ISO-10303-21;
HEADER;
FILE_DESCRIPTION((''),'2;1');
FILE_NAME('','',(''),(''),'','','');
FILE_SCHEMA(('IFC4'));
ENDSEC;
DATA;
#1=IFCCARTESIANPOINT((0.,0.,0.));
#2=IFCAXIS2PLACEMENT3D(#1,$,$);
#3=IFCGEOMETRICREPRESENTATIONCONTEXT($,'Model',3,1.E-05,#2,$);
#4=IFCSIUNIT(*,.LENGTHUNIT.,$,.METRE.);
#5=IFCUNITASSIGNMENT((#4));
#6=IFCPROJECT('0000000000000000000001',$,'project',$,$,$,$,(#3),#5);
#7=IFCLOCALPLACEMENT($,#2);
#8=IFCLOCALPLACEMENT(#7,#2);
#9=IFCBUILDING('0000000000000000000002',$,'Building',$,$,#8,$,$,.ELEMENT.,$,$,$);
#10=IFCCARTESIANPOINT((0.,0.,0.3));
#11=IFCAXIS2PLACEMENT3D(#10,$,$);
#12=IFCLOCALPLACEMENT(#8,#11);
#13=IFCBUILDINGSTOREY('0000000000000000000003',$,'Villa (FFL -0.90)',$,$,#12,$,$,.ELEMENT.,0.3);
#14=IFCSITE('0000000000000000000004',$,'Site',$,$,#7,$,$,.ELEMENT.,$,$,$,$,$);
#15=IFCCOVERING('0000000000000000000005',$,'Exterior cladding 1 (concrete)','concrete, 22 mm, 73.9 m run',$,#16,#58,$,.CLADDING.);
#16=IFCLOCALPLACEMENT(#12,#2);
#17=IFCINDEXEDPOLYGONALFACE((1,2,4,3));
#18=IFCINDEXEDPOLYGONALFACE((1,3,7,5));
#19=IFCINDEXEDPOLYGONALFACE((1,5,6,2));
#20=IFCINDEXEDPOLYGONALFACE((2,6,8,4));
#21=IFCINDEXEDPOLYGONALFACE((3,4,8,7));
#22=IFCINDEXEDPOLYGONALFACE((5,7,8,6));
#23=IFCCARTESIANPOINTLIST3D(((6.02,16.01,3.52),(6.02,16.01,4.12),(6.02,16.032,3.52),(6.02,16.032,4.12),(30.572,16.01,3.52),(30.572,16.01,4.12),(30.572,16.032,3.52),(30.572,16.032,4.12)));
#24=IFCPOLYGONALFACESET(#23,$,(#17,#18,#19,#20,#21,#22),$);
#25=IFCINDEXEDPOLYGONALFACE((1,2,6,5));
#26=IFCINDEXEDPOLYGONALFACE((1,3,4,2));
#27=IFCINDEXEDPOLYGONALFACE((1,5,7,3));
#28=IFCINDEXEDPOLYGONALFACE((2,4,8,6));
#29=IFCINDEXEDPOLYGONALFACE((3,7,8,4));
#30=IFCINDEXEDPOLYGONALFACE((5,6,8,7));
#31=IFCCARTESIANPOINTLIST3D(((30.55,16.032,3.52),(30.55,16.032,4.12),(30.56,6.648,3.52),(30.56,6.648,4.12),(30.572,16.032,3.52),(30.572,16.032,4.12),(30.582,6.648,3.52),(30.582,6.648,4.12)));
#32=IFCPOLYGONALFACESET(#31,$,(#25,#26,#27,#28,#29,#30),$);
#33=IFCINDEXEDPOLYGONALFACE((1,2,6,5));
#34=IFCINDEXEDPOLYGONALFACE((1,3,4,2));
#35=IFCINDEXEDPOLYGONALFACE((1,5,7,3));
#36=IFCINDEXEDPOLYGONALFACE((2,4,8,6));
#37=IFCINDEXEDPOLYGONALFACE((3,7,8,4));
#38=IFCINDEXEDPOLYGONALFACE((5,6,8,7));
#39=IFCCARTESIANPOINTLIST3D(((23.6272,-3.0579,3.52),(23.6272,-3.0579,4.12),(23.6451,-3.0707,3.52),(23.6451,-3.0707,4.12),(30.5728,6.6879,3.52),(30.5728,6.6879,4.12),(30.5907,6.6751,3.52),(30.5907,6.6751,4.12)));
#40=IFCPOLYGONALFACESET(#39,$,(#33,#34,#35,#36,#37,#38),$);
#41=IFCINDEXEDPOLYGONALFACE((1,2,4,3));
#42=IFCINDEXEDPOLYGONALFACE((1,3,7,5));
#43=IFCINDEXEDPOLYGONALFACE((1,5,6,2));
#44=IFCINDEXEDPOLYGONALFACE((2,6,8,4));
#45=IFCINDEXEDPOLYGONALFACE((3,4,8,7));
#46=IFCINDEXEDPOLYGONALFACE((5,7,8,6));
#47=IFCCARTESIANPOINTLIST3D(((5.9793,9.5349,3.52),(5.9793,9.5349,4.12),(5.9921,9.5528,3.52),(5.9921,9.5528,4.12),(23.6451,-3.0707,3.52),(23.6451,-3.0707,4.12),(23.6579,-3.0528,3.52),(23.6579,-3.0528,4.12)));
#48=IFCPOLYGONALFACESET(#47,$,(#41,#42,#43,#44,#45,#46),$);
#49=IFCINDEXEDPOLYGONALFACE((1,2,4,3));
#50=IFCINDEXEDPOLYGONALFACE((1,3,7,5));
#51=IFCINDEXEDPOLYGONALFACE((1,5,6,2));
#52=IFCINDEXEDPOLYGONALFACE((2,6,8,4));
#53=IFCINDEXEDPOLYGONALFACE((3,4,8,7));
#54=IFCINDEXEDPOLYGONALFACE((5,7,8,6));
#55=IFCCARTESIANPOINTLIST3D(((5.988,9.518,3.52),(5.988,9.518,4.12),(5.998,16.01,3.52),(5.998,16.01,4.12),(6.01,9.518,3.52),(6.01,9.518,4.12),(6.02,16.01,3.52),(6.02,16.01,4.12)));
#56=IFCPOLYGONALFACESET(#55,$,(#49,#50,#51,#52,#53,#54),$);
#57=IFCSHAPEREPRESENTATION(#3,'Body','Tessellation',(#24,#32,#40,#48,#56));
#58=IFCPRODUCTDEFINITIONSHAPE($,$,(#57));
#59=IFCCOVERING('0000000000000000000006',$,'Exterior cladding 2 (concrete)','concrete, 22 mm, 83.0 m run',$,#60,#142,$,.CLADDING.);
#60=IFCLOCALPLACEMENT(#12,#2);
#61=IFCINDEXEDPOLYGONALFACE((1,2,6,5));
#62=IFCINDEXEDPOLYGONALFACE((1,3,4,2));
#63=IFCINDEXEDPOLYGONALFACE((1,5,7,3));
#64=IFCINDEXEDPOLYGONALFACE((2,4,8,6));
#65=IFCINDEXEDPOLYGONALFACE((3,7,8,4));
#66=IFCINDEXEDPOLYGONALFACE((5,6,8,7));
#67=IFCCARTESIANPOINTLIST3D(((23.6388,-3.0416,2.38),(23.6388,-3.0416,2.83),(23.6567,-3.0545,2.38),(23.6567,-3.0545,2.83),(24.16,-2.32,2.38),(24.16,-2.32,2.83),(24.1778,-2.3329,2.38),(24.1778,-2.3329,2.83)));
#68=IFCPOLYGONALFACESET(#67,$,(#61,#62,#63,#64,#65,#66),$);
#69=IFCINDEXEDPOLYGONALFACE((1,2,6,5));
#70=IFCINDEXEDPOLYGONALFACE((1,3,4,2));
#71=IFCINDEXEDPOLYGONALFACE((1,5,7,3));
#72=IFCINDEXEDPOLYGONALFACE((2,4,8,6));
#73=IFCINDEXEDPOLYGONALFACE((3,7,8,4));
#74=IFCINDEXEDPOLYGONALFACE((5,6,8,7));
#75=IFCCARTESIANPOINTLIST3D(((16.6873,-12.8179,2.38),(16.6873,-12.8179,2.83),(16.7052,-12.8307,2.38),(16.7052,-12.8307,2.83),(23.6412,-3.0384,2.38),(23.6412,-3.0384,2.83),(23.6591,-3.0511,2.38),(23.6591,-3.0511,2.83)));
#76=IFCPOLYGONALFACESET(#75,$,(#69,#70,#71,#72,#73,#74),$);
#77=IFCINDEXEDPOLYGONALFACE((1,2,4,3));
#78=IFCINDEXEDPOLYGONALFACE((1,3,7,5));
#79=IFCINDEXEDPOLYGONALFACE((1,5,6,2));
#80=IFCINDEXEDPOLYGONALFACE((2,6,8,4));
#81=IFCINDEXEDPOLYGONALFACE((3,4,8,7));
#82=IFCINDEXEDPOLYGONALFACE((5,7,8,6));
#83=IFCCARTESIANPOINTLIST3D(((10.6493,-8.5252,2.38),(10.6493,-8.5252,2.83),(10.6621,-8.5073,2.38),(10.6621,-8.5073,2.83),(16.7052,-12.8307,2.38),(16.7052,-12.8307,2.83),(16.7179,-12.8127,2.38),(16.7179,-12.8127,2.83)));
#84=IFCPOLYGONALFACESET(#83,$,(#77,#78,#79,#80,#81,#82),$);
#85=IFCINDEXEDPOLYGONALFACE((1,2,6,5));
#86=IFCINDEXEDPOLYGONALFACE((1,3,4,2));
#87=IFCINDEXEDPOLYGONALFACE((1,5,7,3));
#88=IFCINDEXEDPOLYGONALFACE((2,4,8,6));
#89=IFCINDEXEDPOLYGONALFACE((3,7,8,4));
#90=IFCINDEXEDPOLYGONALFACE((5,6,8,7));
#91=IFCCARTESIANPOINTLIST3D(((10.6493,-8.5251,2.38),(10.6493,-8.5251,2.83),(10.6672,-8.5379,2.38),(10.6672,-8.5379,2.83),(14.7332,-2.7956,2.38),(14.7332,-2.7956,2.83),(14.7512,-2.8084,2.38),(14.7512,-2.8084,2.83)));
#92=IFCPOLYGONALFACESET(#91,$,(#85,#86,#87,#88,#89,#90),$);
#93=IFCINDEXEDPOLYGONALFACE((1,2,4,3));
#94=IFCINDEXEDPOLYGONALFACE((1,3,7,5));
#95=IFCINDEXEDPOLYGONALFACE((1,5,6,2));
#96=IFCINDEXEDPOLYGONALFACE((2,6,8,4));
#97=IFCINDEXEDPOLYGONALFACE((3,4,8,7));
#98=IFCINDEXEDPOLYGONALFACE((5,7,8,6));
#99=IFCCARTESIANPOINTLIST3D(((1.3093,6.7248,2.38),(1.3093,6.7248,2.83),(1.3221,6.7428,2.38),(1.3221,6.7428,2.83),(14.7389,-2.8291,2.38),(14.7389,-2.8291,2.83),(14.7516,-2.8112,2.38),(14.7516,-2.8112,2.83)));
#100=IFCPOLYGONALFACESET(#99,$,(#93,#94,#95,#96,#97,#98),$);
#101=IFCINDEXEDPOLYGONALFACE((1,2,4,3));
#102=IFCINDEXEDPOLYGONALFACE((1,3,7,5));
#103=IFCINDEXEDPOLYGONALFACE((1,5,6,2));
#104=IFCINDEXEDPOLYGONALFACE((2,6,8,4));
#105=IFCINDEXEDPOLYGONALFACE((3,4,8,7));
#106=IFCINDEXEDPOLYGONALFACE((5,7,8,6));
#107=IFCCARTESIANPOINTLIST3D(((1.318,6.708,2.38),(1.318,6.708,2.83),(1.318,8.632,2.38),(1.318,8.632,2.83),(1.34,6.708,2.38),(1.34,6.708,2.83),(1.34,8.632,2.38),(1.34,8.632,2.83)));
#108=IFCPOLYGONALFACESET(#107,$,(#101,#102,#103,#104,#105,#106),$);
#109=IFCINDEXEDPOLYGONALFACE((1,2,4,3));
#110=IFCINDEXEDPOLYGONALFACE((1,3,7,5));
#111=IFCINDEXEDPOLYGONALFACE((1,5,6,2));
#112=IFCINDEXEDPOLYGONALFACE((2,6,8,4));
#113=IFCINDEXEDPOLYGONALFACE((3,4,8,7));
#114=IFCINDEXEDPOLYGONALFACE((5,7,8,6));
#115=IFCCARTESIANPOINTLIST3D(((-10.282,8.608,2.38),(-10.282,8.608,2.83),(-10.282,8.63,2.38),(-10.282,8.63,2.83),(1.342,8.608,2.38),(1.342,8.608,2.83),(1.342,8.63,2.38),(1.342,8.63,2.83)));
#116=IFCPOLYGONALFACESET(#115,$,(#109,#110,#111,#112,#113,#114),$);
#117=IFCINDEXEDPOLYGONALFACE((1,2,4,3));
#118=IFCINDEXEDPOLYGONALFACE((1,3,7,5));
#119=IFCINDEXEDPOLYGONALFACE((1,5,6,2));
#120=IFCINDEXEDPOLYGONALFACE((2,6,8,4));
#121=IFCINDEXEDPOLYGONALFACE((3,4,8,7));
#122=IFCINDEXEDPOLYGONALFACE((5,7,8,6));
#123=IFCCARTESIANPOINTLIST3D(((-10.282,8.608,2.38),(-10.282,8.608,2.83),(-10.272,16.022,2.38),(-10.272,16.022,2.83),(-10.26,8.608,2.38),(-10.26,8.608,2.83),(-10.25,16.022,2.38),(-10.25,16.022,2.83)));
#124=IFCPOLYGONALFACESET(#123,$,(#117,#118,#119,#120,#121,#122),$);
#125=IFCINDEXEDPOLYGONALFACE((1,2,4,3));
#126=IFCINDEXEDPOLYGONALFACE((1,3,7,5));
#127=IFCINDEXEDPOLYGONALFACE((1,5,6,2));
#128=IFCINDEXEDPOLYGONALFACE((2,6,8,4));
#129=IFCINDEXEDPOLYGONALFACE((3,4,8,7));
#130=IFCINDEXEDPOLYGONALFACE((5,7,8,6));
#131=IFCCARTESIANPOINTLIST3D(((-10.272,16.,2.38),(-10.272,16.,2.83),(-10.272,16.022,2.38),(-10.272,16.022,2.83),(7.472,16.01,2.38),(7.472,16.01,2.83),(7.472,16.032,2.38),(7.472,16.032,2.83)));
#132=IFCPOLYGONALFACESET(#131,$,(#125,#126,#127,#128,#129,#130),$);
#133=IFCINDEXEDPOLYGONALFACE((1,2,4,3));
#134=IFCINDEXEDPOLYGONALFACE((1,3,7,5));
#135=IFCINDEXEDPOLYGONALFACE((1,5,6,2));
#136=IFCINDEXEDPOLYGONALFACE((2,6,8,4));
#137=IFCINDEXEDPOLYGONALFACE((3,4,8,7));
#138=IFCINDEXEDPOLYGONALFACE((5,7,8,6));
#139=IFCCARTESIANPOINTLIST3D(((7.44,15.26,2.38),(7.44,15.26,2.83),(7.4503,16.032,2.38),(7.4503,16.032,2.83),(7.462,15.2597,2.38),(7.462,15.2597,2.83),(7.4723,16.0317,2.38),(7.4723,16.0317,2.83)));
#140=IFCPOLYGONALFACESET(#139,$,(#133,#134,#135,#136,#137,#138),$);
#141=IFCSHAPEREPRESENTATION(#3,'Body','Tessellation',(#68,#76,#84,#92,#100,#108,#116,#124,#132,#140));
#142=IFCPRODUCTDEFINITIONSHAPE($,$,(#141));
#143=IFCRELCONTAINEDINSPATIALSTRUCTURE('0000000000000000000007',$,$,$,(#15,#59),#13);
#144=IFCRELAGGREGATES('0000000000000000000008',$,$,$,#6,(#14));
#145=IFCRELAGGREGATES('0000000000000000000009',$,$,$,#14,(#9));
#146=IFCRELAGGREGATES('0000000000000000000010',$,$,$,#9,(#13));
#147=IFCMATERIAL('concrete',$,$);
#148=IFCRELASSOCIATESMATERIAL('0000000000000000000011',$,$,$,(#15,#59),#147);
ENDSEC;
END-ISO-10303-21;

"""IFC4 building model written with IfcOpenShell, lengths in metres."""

from ifc_helpers import new_model, si_unit, frame, origin, origin_with_axes, place, context, project, spatial, polyline, outline, extrude, material, element, save


model = new_model("IFC4")

# Units and contexts
model_context = context("Model", 3, precision=1e-05, world=origin())
ifc_project = project(units=[si_unit("LENGTHUNIT", "METRE")], contexts=[model_context])

# Site, building, storey
site_placement = place(None, origin())
site = spatial("IfcSite", under=ifc_project, at=site_placement, Name="Site", CompositionType="ELEMENT")
building_placement = place(site_placement, origin())
building = spatial("IfcBuilding", under=site, at=building_placement, Name="Building", CompositionType="ELEMENT")
storey_placement = place(building_placement, frame((0.0, 0.0, 0.3)))
storey = spatial("IfcBuildingStorey", under=building, at=storey_placement, Name="Villa (FFL -0.90)", CompositionType="ELEMENT", Elevation=0.3)

# Coverings
ifc_material_1 = material(Name="concrete")
covering_1_placement = place(storey_placement, origin_with_axes())
element("IfcCovering", 1, at=covering_1_placement, inside=storey, material=ifc_material_1, Name="Exterior cladding 1 (concrete)", Description="concrete, 22 mm, 73.9 m run", PredefinedType="CLADDING", context=model_context, shape_type="SweptSolid", body=[
    extrude(outline(polyline([(6.02, 16.01), (30.572, 16.01), (30.572, 16.032), (6.02, 16.032), (6.02, 16.01)])), frame((0.0, 0.0, 3.52)), (0.0, 0.0, 1.0), 0.6),
    extrude(outline(polyline([(30.55, 16.032), (30.56, 6.648), (30.582, 6.648), (30.572, 16.032), (30.55, 16.032)])), frame((0.0, 0.0, 3.52)), (0.0, 0.0, 1.0), 0.6),
    extrude(outline(polyline([(30.5728, 6.6879), (23.6272, -3.0579), (23.6451, -3.0707), (30.5907, 6.6751), (30.5728, 6.6879)])), frame((0.0, 0.0, 3.52)), (0.0, 0.0, 1.0), 0.6),
    extrude(outline(polyline([(23.6579, -3.0528), (5.9921, 9.5528), (5.9793, 9.5349), (23.6451, -3.0707), (23.6579, -3.0528)])), frame((0.0, 0.0, 3.52)), (0.0, 0.0, 1.0), 0.6),
    extrude(outline(polyline([(6.01, 9.518), (6.02, 16.01), (5.998, 16.01), (5.988, 9.518), (6.01, 9.518)])), frame((0.0, 0.0, 3.52)), (0.0, 0.0, 1.0), 0.6),
])
covering_2_placement = place(storey_placement, origin_with_axes())
element("IfcCovering", 2, at=covering_2_placement, inside=storey, material=ifc_material_1, Name="Exterior cladding 2 (concrete)", Description="concrete, 22 mm, 83.0 m run", PredefinedType="CLADDING", context=model_context, shape_type="SweptSolid", body=[
    extrude(outline(polyline([(24.16, -2.32), (23.6388, -3.0416), (23.6567, -3.0545), (24.1778, -2.3329), (24.16, -2.32)])), frame((0.0, 0.0, 2.38)), (0.0, 0.0, 1.0), 0.45),
    extrude(outline(polyline([(23.6412, -3.0384), (16.6873, -12.8179), (16.7052, -12.8307), (23.6591, -3.0511), (23.6412, -3.0384)])), frame((0.0, 0.0, 2.38)), (0.0, 0.0, 1.0), 0.45),
    extrude(outline(polyline([(16.7179, -12.8127), (10.6621, -8.5073), (10.6493, -8.5252), (16.7052, -12.8307), (16.7179, -12.8127)])), frame((0.0, 0.0, 2.38)), (0.0, 0.0, 1.0), 0.45),
    extrude(outline(polyline([(10.6672, -8.5379), (14.7512, -2.8084), (14.7332, -2.7956), (10.6493, -8.5251), (10.6672, -8.5379)])), frame((0.0, 0.0, 2.38)), (0.0, 0.0, 1.0), 0.45),
    extrude(outline(polyline([(14.7516, -2.8112), (1.3221, 6.7428), (1.3093, 6.7248), (14.7389, -2.8291), (14.7516, -2.8112)])), frame((0.0, 0.0, 2.38)), (0.0, 0.0, 1.0), 0.45),
    extrude(outline(polyline([(1.34, 6.708), (1.34, 8.632), (1.318, 8.632), (1.318, 6.708), (1.34, 6.708)])), frame((0.0, 0.0, 2.38)), (0.0, 0.0, 1.0), 0.45),
    extrude(outline(polyline([(1.342, 8.63), (-10.282, 8.63), (-10.282, 8.608), (1.342, 8.608), (1.342, 8.63)])), frame((0.0, 0.0, 2.38)), (0.0, 0.0, 1.0), 0.45),
    extrude(outline(polyline([(-10.26, 8.608), (-10.25, 16.022), (-10.272, 16.022), (-10.282, 8.608), (-10.26, 8.608)])), frame((0.0, 0.0, 2.38)), (0.0, 0.0, 1.0), 0.45),
    extrude(outline(polyline([(-10.272, 16.0), (7.472, 16.01), (7.472, 16.032), (-10.272, 16.022), (-10.272, 16.0)])), frame((0.0, 0.0, 2.38)), (0.0, 0.0, 1.0), 0.45),
    extrude(outline(polyline([(7.4503, 16.032), (7.44, 15.26), (7.462, 15.2597), (7.4723, 16.0317), (7.4503, 16.032)])), frame((0.0, 0.0, 2.38)), (0.0, 0.0, 1.0), 0.45),
])

save(model, "model.ifc")
